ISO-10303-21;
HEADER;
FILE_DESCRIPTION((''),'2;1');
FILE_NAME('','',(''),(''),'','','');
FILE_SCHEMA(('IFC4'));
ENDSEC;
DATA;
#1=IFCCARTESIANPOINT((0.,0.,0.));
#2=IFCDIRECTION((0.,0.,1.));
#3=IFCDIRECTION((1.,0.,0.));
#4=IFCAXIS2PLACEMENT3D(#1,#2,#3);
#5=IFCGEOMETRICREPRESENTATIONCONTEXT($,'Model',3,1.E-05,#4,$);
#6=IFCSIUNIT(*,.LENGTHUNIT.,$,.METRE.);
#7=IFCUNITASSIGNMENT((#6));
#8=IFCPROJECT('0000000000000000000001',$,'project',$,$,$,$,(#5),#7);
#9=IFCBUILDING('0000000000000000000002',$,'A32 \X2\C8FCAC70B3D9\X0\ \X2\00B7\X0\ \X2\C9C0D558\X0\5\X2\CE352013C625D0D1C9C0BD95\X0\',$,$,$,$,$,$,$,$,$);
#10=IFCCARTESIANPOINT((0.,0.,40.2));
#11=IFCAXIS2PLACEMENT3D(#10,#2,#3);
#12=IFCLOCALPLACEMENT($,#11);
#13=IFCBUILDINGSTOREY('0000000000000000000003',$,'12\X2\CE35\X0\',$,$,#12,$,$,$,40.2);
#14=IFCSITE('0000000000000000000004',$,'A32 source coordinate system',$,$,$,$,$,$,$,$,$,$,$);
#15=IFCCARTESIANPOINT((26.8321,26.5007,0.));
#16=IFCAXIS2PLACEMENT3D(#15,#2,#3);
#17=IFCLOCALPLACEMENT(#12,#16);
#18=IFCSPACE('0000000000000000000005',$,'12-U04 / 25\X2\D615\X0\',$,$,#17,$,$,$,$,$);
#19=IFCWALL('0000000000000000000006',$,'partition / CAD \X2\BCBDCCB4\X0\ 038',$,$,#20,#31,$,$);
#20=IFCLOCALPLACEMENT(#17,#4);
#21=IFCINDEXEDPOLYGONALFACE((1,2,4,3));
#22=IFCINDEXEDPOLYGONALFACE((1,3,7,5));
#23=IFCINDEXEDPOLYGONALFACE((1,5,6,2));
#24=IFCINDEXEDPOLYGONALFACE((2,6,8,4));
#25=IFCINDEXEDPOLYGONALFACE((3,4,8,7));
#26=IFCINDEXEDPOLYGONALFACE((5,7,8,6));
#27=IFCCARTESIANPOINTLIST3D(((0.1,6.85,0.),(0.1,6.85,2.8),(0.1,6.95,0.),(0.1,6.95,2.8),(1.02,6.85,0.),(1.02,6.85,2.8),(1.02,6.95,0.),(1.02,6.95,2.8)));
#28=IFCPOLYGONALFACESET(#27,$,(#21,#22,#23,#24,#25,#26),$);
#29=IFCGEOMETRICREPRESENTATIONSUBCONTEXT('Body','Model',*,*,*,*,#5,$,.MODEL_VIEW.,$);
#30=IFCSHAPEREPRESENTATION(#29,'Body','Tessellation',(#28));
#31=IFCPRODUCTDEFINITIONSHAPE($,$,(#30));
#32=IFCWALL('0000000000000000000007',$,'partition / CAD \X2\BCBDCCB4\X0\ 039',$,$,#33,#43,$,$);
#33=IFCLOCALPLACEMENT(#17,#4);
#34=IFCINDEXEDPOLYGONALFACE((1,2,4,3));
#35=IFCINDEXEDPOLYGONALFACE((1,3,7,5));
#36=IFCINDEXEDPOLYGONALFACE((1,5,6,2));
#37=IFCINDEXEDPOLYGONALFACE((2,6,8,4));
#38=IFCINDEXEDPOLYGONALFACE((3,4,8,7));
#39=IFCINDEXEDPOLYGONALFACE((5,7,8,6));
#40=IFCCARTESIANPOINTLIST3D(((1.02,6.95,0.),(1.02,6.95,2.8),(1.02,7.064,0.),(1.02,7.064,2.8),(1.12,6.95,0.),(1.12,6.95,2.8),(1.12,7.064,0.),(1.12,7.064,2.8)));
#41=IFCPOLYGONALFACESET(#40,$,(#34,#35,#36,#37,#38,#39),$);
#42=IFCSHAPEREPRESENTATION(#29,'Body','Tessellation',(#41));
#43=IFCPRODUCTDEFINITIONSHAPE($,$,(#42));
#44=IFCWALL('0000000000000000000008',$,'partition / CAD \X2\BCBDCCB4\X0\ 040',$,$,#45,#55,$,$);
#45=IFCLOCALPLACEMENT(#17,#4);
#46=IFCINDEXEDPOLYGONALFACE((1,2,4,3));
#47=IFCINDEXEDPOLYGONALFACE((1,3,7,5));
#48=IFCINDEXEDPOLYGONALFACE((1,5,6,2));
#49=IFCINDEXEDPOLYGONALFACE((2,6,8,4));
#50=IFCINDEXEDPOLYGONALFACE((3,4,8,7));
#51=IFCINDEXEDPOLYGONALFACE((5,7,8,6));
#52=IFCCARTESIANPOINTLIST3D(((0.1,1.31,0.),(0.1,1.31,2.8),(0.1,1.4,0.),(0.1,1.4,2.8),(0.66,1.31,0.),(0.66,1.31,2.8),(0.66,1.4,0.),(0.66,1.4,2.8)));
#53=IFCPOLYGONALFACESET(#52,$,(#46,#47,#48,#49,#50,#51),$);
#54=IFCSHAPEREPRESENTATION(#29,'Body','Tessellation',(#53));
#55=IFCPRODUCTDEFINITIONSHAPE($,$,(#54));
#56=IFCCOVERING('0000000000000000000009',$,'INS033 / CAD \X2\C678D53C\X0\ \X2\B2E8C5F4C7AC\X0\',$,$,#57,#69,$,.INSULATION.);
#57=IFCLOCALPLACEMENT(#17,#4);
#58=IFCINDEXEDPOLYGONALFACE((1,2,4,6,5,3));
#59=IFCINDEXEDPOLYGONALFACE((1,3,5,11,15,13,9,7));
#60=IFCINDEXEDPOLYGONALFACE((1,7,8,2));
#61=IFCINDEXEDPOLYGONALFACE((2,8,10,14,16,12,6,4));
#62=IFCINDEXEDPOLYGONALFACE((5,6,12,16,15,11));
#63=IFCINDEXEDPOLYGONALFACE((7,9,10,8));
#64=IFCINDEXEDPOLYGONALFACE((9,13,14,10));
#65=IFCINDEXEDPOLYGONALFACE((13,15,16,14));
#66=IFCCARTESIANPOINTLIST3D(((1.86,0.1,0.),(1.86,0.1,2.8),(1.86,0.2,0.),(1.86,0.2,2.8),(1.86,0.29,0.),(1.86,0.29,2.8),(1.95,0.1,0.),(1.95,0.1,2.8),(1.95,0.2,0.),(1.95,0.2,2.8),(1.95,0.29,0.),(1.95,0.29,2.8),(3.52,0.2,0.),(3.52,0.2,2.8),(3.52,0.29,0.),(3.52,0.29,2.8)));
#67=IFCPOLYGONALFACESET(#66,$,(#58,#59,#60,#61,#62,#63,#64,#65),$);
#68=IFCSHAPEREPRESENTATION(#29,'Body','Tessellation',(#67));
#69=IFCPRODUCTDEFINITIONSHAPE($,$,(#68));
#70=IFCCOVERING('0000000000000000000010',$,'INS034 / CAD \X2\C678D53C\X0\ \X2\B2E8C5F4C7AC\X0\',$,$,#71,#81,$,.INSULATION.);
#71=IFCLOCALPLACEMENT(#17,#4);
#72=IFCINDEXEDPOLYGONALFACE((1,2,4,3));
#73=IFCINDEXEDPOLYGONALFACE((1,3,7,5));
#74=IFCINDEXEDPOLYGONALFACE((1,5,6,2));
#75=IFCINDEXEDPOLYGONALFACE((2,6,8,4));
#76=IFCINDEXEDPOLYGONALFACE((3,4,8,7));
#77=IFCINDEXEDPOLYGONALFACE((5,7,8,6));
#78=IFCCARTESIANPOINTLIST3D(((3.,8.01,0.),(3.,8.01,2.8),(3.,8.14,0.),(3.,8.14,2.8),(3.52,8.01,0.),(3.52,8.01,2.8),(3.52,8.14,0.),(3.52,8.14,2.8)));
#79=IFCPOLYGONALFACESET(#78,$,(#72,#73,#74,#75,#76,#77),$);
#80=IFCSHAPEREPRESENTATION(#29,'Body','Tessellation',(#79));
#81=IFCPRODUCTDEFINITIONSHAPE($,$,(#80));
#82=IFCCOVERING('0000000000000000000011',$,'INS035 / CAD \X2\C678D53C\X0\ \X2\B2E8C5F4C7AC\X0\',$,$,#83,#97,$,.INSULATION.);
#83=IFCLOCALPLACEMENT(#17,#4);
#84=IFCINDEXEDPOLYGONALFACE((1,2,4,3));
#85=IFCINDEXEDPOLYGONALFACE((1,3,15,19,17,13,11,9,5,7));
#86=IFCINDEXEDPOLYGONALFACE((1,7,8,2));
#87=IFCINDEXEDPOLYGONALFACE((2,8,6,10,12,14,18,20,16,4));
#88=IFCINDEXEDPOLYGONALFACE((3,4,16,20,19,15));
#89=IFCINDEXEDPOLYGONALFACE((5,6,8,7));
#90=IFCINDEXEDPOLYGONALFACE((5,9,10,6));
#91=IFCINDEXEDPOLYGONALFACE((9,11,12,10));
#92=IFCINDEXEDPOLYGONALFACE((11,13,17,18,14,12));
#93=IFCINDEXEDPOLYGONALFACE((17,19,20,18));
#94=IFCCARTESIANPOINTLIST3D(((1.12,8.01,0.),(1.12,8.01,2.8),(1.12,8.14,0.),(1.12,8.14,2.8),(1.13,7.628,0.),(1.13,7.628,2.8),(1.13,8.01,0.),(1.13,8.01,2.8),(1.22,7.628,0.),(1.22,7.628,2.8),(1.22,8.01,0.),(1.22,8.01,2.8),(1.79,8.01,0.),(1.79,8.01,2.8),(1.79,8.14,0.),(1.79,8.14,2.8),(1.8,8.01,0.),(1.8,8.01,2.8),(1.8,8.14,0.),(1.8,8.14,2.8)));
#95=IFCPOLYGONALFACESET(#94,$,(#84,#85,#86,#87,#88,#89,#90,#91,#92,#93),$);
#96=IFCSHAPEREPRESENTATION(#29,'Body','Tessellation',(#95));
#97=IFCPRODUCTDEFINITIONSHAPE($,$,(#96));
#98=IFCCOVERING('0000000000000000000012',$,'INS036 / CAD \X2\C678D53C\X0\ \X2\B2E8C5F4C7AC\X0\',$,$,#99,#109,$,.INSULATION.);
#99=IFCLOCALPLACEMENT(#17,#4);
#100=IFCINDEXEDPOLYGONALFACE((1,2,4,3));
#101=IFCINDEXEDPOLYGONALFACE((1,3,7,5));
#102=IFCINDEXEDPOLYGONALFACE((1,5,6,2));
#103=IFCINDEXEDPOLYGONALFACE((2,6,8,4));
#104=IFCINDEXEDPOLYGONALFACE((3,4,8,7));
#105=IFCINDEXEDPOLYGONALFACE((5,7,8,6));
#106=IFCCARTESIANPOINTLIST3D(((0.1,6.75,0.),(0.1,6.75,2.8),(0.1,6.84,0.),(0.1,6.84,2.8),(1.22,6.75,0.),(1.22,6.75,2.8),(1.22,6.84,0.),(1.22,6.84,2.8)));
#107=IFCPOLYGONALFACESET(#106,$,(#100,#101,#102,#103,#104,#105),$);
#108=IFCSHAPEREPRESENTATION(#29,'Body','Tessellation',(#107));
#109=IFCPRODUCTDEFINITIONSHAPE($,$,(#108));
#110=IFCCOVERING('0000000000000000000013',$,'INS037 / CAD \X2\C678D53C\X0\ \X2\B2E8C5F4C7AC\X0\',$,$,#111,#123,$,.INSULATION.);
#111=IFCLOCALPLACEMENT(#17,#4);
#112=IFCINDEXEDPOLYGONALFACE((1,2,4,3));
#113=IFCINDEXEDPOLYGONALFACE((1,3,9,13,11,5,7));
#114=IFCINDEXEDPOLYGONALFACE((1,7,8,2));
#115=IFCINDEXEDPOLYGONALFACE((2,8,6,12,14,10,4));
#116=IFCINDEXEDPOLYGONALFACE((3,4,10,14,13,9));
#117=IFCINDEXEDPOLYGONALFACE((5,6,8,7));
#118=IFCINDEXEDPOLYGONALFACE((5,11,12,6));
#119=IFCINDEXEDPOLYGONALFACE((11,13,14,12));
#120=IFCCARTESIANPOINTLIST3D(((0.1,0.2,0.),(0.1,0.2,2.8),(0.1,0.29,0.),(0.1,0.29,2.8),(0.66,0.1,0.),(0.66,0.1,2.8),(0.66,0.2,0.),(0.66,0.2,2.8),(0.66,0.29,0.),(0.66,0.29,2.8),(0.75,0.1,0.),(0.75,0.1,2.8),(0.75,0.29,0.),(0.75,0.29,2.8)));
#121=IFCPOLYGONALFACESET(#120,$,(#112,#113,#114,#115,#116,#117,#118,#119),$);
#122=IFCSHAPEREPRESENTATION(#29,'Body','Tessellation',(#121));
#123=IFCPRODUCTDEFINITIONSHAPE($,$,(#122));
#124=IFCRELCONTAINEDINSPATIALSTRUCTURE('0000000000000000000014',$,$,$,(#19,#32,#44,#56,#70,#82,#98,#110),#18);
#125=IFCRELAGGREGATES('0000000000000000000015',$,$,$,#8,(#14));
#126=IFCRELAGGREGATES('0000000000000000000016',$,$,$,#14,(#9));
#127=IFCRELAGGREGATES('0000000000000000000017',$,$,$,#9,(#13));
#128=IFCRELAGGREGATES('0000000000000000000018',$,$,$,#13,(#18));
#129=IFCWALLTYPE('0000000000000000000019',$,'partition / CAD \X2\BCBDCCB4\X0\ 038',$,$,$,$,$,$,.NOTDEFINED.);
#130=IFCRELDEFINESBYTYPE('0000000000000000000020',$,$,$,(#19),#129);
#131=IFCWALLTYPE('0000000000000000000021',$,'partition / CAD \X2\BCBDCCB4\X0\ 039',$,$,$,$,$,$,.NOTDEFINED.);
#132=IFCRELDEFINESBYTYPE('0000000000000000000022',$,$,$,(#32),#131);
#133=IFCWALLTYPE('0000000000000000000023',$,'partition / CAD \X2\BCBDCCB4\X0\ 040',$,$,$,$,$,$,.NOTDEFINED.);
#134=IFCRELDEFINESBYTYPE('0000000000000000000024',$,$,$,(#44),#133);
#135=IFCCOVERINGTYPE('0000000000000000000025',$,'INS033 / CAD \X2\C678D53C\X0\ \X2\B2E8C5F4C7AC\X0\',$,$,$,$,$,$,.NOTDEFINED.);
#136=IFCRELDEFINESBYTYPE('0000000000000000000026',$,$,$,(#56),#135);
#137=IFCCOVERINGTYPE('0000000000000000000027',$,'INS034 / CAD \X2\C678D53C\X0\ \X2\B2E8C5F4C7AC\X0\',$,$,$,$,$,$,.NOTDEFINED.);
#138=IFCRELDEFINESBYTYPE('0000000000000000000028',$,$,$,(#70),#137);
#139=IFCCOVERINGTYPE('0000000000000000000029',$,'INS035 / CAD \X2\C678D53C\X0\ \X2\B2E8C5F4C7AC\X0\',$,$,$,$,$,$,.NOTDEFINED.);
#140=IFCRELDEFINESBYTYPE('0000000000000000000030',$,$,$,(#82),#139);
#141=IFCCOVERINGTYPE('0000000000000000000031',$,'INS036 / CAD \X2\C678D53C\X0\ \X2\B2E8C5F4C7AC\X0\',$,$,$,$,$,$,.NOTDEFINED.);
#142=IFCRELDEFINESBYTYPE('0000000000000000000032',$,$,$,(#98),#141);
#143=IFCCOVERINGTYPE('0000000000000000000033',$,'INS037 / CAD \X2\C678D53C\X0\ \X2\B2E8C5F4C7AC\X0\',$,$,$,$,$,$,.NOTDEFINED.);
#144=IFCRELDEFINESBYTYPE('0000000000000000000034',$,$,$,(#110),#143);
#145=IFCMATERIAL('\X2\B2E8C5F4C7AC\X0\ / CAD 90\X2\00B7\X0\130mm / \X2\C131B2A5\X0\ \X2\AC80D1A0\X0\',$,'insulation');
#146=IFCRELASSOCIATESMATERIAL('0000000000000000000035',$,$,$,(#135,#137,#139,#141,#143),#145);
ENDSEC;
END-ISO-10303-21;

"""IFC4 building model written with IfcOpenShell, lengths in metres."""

from ifc_helpers import new_model, si_unit, frame, origin, origin_with_axes, place, context, subcontext, project, spatial, polyline, outline, extrude, source, transform, mapped, material, type_object, type_shapes, element, save


model = new_model("IFC4")

# Units and contexts
model_context = context("Model", 3, precision=1e-05, world=origin_with_axes())
body_context = subcontext(model_context, "Body", "Model", "MODEL_VIEW")
ifc_project = project(units=[si_unit("LENGTHUNIT", "METRE")], contexts=[model_context])

# Site, building, storey, space
storey_placement = place(None, frame((0.0, 0.0, 40.2), z_axis=(0.0, 0.0, 1.0), x_axis=(1.0, 0.0, 0.0)))
space_placement = place(storey_placement, frame((26.8321, 26.5007, 0.0), z_axis=(0.0, 0.0, 1.0), x_axis=(1.0, 0.0, 0.0)))
site = spatial("IfcSite", under=ifc_project, Name="A32 source coordinate system")
building = spatial("IfcBuilding", under=site, Name="A32 주거동 · 지하5층–옥탑지붕")
storey = spatial("IfcBuildingStorey", under=building, at=storey_placement, Name="12층", Elevation=40.2)
space = spatial("IfcSpace", under=storey, at=space_placement, Name="12-U04 / 25형")

# Walls
wall_type_1 = type_object("IfcWallType", Name="partition / CAD 벽체 038", PredefinedType="NOTDEFINED")
shared_shape_1 = source(origin(), body_context, "Body", "SweptSolid", [
    extrude(outline(polyline([(0.1, 6.95), (1.02, 6.95), (1.02, 6.85), (0.1, 6.85), (0.1, 6.95)])), origin(), (0.0, 0.0, 1.0), 2.8),
])
type_shapes(wall_type_1, [shared_shape_1])
wall_1_placement = place(space_placement, origin_with_axes())
element("IfcWall", 1, at=wall_1_placement, inside=space, type_object=wall_type_1, Name="partition / CAD 벽체 038", context=body_context, shape_type="MappedRepresentation", body=[
    mapped(shared_shape_1, transform((0.0, 0.0, 0.0), scale=1.0)),
])
wall_type_2 = type_object("IfcWallType", Name="partition / CAD 벽체 039", PredefinedType="NOTDEFINED")
shared_shape_2 = source(origin(), body_context, "Body", "SweptSolid", [
    extrude(outline(polyline([(1.02, 6.95), (1.02, 7.064), (1.12, 7.064), (1.12, 6.95), (1.02, 6.95)])), origin(), (0.0, 0.0, 1.0), 2.8),
])
type_shapes(wall_type_2, [shared_shape_2])
wall_2_placement = place(space_placement, origin_with_axes())
element("IfcWall", 2, at=wall_2_placement, inside=space, type_object=wall_type_2, Name="partition / CAD 벽체 039", context=body_context, shape_type="MappedRepresentation", body=[
    mapped(shared_shape_2, transform((0.0, 0.0, 0.0), scale=1.0)),
])
wall_type_3 = type_object("IfcWallType", Name="partition / CAD 벽체 040", PredefinedType="NOTDEFINED")
shared_shape_3 = source(origin(), body_context, "Body", "SweptSolid", [
    extrude(outline(polyline([(0.1, 1.4), (0.66, 1.4), (0.66, 1.31), (0.1, 1.31), (0.1, 1.4)])), origin(), (0.0, 0.0, 1.0), 2.8),
])
type_shapes(wall_type_3, [shared_shape_3])
wall_3_placement = place(space_placement, origin_with_axes())
element("IfcWall", 3, at=wall_3_placement, inside=space, type_object=wall_type_3, Name="partition / CAD 벽체 040", context=body_context, shape_type="MappedRepresentation", body=[
    mapped(shared_shape_3, transform((0.0, 0.0, 0.0), scale=1.0)),
])

# Coverings
ifc_material = material(Name="단열재 / CAD 90·130mm / 성능 검토", Category="insulation")
covering_type_1 = type_object("IfcCoveringType", Name="INS033 / CAD 외피 단열재", PredefinedType="NOTDEFINED", material=ifc_material)
shared_shape_4 = source(origin(), body_context, "Body", "SweptSolid", [
    extrude(outline(polyline([(1.95, 0.29), (3.52, 0.29), (3.52, 0.2), (1.95, 0.2), (1.95, 0.1), (1.86, 0.1), (1.86, 0.2), (1.86, 0.29), (1.95, 0.29)])), origin(), (0.0, 0.0, 1.0), 2.8),
])
type_shapes(covering_type_1, [shared_shape_4])
covering_1_placement = place(space_placement, origin_with_axes())
element("IfcCovering", 4, at=covering_1_placement, inside=space, type_object=covering_type_1, Name="INS033 / CAD 외피 단열재", PredefinedType="INSULATION", context=body_context, shape_type="MappedRepresentation", body=[
    mapped(shared_shape_4, transform((0.0, 0.0, 0.0), scale=1.0)),
])
covering_type_2 = type_object("IfcCoveringType", Name="INS034 / CAD 외피 단열재", PredefinedType="NOTDEFINED", material=ifc_material)
shared_shape_5 = source(origin(), body_context, "Body", "SweptSolid", [
    extrude(outline(polyline([(3.52, 8.01), (3.0, 8.01), (3.0, 8.14), (3.52, 8.14), (3.52, 8.01)])), origin(), (0.0, 0.0, 1.0), 2.8),
])
type_shapes(covering_type_2, [shared_shape_5])
covering_2_placement = place(space_placement, origin_with_axes())
element("IfcCovering", 5, at=covering_2_placement, inside=space, type_object=covering_type_2, Name="INS034 / CAD 외피 단열재", PredefinedType="INSULATION", context=body_context, shape_type="MappedRepresentation", body=[
    mapped(shared_shape_5, transform((0.0, 0.0, 0.0), scale=1.0)),
])
covering_type_3 = type_object("IfcCoveringType", Name="INS035 / CAD 외피 단열재", PredefinedType="NOTDEFINED", material=ifc_material)
shared_shape_6 = source(origin(), body_context, "Body", "SweptSolid", [
    extrude(outline(polyline([(1.8, 8.01), (1.79, 8.01), (1.22, 8.01), (1.22, 7.628), (1.13, 7.628), (1.13, 8.01), (1.12, 8.01), (1.12, 8.14), (1.79, 8.14), (1.8, 8.14), (1.8, 8.01)])), origin(), (0.0, 0.0, 1.0), 2.8),
])
type_shapes(covering_type_3, [shared_shape_6])
covering_3_placement = place(space_placement, origin_with_axes())
element("IfcCovering", 6, at=covering_3_placement, inside=space, type_object=covering_type_3, Name="INS035 / CAD 외피 단열재", PredefinedType="INSULATION", context=body_context, shape_type="MappedRepresentation", body=[
    mapped(shared_shape_6, transform((0.0, 0.0, 0.0), scale=1.0)),
])
covering_type_4 = type_object("IfcCoveringType", Name="INS036 / CAD 외피 단열재", PredefinedType="NOTDEFINED", material=ifc_material)
shared_shape_7 = source(origin(), body_context, "Body", "SweptSolid", [
    extrude(outline(polyline([(1.22, 6.84), (1.22, 6.75), (0.1, 6.75), (0.1, 6.84), (1.22, 6.84)])), origin(), (0.0, 0.0, 1.0), 2.8),
])
type_shapes(covering_type_4, [shared_shape_7])
covering_4_placement = place(space_placement, origin_with_axes())
element("IfcCovering", 7, at=covering_4_placement, inside=space, type_object=covering_type_4, Name="INS036 / CAD 외피 단열재", PredefinedType="INSULATION", context=body_context, shape_type="MappedRepresentation", body=[
    mapped(shared_shape_7, transform((0.0, 0.0, 0.0), scale=1.0)),
])
covering_type_5 = type_object("IfcCoveringType", Name="INS037 / CAD 외피 단열재", PredefinedType="NOTDEFINED", material=ifc_material)
shared_shape_8 = source(origin(), body_context, "Body", "SweptSolid", [
    extrude(outline(polyline([(0.1, 0.2), (0.1, 0.29), (0.66, 0.29), (0.75, 0.29), (0.75, 0.1), (0.66, 0.1), (0.66, 0.2), (0.1, 0.2)])), origin(), (0.0, 0.0, 1.0), 2.8),
])
type_shapes(covering_type_5, [shared_shape_8])
covering_5_placement = place(space_placement, origin_with_axes())
element("IfcCovering", 8, at=covering_5_placement, inside=space, type_object=covering_type_5, Name="INS037 / CAD 외피 단열재", PredefinedType="INSULATION", context=body_context, shape_type="MappedRepresentation", body=[
    mapped(shared_shape_8, transform((0.0, 0.0, 0.0), scale=1.0)),
])

save(model, "model.ifc")
